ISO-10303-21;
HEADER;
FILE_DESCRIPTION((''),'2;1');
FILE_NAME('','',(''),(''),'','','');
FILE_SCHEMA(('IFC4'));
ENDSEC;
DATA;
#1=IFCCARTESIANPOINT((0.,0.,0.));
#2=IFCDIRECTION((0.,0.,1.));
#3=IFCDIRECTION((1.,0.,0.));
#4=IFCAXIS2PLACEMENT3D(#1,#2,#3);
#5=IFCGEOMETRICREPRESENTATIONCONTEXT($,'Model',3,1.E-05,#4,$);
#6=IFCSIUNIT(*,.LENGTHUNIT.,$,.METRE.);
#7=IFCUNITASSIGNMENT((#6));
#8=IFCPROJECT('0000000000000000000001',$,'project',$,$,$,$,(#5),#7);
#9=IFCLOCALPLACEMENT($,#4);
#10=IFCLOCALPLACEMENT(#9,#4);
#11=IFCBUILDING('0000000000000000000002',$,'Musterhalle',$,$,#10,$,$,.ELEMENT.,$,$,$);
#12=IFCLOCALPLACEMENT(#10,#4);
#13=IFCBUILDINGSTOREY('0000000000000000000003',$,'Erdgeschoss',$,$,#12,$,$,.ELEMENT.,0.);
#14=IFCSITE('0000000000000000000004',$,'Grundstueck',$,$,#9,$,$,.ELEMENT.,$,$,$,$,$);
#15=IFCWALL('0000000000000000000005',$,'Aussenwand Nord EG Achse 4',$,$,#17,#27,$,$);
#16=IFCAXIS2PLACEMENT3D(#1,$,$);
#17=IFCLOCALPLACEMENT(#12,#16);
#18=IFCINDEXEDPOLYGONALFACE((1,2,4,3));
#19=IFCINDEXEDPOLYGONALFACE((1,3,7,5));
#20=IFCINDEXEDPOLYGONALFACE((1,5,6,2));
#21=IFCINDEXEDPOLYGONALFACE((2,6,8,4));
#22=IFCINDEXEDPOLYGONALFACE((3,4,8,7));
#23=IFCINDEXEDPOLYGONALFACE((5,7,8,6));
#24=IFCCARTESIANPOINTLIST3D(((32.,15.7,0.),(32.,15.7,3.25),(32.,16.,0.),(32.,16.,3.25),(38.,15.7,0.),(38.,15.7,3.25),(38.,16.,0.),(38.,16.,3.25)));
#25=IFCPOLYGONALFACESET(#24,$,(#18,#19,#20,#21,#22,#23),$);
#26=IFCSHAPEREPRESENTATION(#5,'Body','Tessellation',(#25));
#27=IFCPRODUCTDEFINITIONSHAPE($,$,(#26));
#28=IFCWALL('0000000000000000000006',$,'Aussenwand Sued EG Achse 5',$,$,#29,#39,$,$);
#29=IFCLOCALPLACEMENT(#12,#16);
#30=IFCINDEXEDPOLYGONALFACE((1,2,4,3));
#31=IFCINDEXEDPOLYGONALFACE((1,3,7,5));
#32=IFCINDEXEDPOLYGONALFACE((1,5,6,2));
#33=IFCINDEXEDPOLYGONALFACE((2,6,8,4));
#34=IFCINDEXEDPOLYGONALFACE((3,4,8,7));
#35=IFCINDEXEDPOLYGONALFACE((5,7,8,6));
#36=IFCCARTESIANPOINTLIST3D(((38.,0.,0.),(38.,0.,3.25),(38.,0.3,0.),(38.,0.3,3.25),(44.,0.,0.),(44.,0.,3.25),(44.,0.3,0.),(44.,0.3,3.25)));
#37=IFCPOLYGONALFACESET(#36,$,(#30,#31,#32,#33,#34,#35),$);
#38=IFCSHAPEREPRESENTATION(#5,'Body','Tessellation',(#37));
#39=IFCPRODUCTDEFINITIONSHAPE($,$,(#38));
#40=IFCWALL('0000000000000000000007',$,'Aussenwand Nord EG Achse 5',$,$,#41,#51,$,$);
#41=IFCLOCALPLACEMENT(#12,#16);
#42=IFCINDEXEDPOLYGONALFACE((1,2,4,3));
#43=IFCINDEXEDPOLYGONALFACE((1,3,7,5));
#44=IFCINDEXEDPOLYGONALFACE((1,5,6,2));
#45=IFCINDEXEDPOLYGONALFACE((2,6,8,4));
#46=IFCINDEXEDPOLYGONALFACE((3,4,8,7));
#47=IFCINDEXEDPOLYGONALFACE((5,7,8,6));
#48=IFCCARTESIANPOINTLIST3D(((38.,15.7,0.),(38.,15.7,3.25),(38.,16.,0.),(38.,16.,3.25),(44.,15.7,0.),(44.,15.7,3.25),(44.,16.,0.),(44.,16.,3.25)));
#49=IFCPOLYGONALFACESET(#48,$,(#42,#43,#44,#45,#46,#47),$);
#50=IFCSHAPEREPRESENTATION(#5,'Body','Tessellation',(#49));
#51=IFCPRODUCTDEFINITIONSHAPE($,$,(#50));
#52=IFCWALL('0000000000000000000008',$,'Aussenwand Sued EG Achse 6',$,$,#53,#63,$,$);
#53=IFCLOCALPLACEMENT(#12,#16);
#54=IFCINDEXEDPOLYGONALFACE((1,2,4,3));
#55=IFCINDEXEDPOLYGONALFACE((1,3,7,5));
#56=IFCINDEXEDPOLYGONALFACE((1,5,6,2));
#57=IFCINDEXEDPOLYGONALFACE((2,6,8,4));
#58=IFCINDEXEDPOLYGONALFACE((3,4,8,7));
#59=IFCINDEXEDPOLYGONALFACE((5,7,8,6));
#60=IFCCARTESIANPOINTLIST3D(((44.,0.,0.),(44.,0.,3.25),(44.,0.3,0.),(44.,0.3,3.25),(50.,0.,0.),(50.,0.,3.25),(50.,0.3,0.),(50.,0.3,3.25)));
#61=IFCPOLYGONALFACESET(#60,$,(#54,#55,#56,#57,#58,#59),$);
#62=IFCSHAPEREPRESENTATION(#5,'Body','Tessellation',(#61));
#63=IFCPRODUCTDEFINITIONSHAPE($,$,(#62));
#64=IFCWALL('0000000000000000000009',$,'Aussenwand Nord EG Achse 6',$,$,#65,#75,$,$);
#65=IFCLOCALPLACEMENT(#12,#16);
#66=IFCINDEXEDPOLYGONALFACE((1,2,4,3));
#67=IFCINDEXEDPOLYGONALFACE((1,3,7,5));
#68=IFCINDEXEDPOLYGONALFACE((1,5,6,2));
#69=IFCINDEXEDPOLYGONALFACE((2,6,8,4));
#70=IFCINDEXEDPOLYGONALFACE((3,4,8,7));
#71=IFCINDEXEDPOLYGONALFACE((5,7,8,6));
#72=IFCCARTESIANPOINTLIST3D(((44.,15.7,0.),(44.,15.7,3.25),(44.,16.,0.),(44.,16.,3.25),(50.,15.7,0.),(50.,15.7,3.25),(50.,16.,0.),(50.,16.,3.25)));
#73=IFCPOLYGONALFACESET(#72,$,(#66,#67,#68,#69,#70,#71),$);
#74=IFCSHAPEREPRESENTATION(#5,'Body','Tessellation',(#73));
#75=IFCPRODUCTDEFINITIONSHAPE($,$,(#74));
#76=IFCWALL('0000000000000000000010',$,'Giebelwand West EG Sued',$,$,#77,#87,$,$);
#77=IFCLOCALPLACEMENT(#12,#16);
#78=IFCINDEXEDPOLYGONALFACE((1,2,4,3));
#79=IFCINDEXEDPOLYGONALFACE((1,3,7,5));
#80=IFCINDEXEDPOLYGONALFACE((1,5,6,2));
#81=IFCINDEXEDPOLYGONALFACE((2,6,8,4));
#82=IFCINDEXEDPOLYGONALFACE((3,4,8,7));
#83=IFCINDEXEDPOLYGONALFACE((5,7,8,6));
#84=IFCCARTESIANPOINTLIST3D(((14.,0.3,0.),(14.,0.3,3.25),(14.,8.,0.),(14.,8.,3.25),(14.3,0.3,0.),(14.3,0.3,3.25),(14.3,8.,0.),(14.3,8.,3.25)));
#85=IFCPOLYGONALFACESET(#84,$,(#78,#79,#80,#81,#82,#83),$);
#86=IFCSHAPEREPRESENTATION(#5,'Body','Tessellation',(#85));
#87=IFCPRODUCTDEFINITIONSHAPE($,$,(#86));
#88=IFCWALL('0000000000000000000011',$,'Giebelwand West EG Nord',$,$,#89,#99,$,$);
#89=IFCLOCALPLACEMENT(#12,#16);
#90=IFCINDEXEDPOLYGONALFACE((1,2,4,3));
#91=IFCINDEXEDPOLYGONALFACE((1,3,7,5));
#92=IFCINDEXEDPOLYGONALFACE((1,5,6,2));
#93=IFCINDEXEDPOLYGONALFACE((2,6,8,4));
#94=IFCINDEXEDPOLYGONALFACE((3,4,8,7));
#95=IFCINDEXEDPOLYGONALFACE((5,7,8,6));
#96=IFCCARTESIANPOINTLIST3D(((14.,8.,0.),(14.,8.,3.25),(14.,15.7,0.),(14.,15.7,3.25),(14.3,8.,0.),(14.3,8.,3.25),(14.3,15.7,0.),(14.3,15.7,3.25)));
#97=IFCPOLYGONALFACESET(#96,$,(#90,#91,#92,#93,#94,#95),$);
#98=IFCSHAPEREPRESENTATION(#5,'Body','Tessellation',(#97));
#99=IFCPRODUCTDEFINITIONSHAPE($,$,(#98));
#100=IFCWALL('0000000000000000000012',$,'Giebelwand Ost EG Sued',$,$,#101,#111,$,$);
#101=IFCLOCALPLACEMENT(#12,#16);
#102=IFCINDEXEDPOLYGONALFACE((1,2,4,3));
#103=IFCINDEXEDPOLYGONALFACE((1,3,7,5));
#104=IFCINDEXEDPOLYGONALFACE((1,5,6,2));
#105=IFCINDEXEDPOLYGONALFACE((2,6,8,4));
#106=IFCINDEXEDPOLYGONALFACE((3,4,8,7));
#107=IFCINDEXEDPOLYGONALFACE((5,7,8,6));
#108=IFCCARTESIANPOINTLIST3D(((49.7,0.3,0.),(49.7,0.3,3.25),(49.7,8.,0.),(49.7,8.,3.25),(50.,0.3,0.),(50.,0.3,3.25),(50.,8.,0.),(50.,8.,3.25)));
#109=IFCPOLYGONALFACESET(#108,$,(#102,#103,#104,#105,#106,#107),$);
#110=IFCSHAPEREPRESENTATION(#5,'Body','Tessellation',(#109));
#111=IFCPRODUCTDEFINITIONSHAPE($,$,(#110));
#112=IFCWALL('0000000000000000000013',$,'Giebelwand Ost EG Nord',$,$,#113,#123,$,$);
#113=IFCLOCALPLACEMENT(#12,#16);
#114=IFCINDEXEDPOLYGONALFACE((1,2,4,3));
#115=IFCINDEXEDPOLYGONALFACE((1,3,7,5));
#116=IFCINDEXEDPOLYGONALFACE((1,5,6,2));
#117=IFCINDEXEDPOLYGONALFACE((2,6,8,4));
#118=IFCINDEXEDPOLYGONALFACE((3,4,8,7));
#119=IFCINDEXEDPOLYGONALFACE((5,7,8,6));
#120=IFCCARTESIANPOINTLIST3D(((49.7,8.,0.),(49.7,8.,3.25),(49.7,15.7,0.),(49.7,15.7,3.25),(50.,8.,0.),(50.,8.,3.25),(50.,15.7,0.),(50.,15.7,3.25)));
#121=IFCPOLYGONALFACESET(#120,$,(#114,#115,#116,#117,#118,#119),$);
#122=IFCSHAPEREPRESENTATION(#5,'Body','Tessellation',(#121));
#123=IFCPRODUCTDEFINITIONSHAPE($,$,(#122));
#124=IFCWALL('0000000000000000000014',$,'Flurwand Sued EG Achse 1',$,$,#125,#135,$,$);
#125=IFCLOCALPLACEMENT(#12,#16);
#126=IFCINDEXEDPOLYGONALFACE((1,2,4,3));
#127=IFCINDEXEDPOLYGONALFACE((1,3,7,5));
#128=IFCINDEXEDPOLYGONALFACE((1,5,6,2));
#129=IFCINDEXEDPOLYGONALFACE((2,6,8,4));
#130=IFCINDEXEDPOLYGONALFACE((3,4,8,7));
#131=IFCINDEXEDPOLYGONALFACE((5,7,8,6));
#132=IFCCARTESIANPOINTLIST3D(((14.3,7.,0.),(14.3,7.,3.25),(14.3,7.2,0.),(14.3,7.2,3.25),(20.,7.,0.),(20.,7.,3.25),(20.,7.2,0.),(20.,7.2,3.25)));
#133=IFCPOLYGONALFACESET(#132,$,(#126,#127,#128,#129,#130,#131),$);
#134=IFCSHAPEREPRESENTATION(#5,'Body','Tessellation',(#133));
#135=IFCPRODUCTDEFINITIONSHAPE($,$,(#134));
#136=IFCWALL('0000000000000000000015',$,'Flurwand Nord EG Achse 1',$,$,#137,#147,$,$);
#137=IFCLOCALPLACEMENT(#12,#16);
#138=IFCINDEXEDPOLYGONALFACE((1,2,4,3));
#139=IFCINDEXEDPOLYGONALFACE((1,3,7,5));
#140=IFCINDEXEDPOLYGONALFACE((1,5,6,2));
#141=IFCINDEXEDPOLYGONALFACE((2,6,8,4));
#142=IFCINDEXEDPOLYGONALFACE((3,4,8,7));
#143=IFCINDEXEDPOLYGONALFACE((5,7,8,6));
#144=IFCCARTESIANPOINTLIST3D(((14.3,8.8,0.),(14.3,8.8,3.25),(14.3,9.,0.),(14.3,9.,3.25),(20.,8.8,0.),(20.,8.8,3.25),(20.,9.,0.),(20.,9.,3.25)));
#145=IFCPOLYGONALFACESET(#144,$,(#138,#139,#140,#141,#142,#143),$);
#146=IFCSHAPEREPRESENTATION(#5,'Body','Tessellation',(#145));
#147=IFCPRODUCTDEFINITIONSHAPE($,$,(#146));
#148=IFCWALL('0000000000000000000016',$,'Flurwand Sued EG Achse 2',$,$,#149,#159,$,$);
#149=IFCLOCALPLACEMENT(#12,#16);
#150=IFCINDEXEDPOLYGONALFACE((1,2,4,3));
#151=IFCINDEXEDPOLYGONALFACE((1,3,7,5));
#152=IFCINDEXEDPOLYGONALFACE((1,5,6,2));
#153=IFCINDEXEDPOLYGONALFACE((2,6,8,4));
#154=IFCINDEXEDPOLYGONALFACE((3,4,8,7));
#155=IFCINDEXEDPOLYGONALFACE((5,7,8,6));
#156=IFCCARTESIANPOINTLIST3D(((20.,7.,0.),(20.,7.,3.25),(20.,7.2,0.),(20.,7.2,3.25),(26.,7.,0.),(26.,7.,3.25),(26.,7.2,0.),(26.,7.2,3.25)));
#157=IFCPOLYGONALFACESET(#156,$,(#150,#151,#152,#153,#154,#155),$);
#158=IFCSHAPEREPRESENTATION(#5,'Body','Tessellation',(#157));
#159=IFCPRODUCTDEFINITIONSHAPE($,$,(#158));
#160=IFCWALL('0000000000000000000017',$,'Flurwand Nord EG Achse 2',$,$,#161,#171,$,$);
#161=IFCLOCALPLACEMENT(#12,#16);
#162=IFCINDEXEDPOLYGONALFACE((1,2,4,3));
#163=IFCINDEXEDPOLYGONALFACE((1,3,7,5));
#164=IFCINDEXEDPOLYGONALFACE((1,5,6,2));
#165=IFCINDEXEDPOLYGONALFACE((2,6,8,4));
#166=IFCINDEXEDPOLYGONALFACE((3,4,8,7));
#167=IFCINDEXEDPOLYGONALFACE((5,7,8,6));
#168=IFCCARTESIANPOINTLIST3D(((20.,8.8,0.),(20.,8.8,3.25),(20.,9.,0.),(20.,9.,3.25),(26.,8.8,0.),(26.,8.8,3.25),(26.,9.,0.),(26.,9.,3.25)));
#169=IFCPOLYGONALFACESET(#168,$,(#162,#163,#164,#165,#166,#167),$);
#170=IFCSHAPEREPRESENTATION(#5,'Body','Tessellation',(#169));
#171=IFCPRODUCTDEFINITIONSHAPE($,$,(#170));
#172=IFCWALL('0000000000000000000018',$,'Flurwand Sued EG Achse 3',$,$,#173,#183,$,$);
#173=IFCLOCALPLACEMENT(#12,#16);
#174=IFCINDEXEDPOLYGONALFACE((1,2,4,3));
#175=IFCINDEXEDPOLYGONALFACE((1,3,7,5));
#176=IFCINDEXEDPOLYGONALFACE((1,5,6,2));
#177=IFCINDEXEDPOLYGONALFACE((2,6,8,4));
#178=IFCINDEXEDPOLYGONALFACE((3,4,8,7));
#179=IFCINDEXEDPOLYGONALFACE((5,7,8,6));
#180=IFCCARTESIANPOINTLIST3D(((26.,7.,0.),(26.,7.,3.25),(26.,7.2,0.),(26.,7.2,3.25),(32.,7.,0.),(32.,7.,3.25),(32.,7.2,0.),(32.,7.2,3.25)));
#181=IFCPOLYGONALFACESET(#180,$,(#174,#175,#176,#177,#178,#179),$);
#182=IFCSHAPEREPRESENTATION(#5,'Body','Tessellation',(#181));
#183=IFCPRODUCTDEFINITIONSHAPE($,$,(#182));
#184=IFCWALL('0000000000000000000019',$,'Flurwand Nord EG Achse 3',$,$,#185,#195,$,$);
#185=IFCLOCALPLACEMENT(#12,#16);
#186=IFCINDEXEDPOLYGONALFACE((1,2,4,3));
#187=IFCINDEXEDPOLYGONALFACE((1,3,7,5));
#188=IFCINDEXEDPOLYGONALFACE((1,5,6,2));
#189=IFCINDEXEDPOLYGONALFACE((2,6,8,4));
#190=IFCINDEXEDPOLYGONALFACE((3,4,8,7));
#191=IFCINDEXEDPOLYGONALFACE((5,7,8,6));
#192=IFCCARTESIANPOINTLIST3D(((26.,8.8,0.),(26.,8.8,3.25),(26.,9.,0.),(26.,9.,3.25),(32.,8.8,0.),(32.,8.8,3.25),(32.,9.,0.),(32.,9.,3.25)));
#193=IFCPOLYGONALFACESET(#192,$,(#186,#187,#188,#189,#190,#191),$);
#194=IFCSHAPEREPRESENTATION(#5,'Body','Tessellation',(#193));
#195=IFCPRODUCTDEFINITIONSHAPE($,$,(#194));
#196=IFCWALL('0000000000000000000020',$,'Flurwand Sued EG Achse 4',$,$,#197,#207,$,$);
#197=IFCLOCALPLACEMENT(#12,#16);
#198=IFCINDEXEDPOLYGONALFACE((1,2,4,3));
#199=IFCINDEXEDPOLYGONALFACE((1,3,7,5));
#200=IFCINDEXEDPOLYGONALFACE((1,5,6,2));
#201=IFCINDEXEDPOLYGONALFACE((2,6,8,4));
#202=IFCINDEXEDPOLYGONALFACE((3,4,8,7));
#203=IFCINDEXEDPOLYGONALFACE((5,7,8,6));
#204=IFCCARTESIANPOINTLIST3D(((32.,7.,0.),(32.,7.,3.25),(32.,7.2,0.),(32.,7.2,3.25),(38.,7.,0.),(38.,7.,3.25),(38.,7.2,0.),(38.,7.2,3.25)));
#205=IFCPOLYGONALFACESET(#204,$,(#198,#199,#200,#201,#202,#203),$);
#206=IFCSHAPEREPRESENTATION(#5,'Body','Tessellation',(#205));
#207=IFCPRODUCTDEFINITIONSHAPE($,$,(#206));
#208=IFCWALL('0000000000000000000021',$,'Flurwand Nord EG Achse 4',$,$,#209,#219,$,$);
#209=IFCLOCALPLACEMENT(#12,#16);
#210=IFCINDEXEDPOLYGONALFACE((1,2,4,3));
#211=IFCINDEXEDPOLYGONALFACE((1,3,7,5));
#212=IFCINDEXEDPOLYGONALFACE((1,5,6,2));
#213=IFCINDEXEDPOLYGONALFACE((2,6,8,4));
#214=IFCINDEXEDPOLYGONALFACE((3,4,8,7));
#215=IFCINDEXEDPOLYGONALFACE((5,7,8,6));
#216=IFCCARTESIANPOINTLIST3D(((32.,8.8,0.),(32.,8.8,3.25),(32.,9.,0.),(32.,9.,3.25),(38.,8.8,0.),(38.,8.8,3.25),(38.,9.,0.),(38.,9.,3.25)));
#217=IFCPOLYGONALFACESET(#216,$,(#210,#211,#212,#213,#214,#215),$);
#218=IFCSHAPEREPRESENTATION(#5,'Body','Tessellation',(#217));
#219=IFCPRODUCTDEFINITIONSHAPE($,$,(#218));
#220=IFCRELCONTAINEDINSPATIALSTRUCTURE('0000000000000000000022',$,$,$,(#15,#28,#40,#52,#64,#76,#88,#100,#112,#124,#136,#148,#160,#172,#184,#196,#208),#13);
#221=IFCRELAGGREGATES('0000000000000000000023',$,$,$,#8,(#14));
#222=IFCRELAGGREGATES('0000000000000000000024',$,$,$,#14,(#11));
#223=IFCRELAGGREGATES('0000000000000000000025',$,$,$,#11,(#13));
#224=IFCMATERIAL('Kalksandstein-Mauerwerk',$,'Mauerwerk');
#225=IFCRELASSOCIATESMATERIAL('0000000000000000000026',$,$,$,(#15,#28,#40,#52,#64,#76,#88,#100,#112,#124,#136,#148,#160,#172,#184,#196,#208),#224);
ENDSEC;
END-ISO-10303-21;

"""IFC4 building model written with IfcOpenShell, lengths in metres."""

from ifc_helpers import new_model, si_unit, frame, origin_with_axes, origin_2d, place, context, project, spatial, rectangle, extrude, material, element, save


model = new_model("IFC4")

# Units and contexts
model_context = context("Model", 3, precision=1e-05, world=origin_with_axes())
ifc_project = project(units=[si_unit("LENGTHUNIT", "METRE")], contexts=[model_context])

# Site, building, storey
site_placement = place(None, origin_with_axes())
site = spatial("IfcSite", under=ifc_project, at=site_placement, Name="Grundstueck", CompositionType="ELEMENT")
building_placement = place(site_placement, origin_with_axes())
building = spatial("IfcBuilding", under=site, at=building_placement, Name="Musterhalle", CompositionType="ELEMENT")
storey_placement = place(building_placement, origin_with_axes())
storey = spatial("IfcBuildingStorey", under=building, at=storey_placement, Name="Erdgeschoss", CompositionType="ELEMENT", Elevation=0.0)

# Walls
ifc_material_1 = material(Name="Kalksandstein-Mauerwerk", Category="Mauerwerk")
placement = place(storey_placement, origin_with_axes())
element("IfcWall", 1, at=placement, inside=storey, material=ifc_material_1, Name="Aussenwand Nord EG Achse 4", context=model_context, shape_type="SweptSolid", body=[
    extrude(rectangle(XDim=6.0, YDim=0.3, at=origin_2d()), frame((35.0, 15.85, 0.0), z_axis=(0.0, 0.0, 1.0), x_axis=(1.0, 0.0, 0.0)), (0.0, 0.0, 1.0), 3.25),
])
element("IfcWall", 2, at=placement, inside=storey, material=ifc_material_1, Name="Aussenwand Sued EG Achse 5", context=model_context, shape_type="SweptSolid", body=[
    extrude(rectangle(XDim=6.0, YDim=0.3, at=origin_2d()), frame((41.0, 0.15, 0.0), z_axis=(0.0, 0.0, 1.0), x_axis=(1.0, 0.0, 0.0)), (0.0, 0.0, 1.0), 3.25),
])
element("IfcWall", 3, at=placement, inside=storey, material=ifc_material_1, Name="Aussenwand Nord EG Achse 5", context=model_context, shape_type="SweptSolid", body=[
    extrude(rectangle(XDim=6.0, YDim=0.3, at=origin_2d()), frame((41.0, 15.85, 0.0), z_axis=(0.0, 0.0, 1.0), x_axis=(1.0, 0.0, 0.0)), (0.0, 0.0, 1.0), 3.25),
])
element("IfcWall", 4, at=placement, inside=storey, material=ifc_material_1, Name="Aussenwand Sued EG Achse 6", context=model_context, shape_type="SweptSolid", body=[
    extrude(rectangle(XDim=6.0, YDim=0.3, at=origin_2d()), frame((47.0, 0.15, 0.0), z_axis=(0.0, 0.0, 1.0), x_axis=(1.0, 0.0, 0.0)), (0.0, 0.0, 1.0), 3.25),
])
element("IfcWall", 5, at=placement, inside=storey, material=ifc_material_1, Name="Aussenwand Nord EG Achse 6", context=model_context, shape_type="SweptSolid", body=[
    extrude(rectangle(XDim=6.0, YDim=0.3, at=origin_2d()), frame((47.0, 15.85, 0.0), z_axis=(0.0, 0.0, 1.0), x_axis=(1.0, 0.0, 0.0)), (0.0, 0.0, 1.0), 3.25),
])
element("IfcWall", 6, at=placement, inside=storey, material=ifc_material_1, Name="Giebelwand West EG Sued", context=model_context, shape_type="SweptSolid", body=[
    extrude(rectangle(XDim=0.3, YDim=7.7, at=origin_2d()), frame((14.15, 4.15, 0.0), z_axis=(0.0, 0.0, 1.0), x_axis=(1.0, 0.0, 0.0)), (0.0, 0.0, 1.0), 3.25),
])
element("IfcWall", 7, at=placement, inside=storey, material=ifc_material_1, Name="Giebelwand West EG Nord", context=model_context, shape_type="SweptSolid", body=[
    extrude(rectangle(XDim=0.3, YDim=7.7, at=origin_2d()), frame((14.15, 11.85, 0.0), z_axis=(0.0, 0.0, 1.0), x_axis=(1.0, 0.0, 0.0)), (0.0, 0.0, 1.0), 3.25),
])
element("IfcWall", 8, at=placement, inside=storey, material=ifc_material_1, Name="Giebelwand Ost EG Sued", context=model_context, shape_type="SweptSolid", body=[
    extrude(rectangle(XDim=0.3, YDim=7.7, at=origin_2d()), frame((49.85, 4.15, 0.0), z_axis=(0.0, 0.0, 1.0), x_axis=(1.0, 0.0, 0.0)), (0.0, 0.0, 1.0), 3.25),
])
element("IfcWall", 9, at=placement, inside=storey, material=ifc_material_1, Name="Giebelwand Ost EG Nord", context=model_context, shape_type="SweptSolid", body=[
    extrude(rectangle(XDim=0.3, YDim=7.7, at=origin_2d()), frame((49.85, 11.85, 0.0), z_axis=(0.0, 0.0, 1.0), x_axis=(1.0, 0.0, 0.0)), (0.0, 0.0, 1.0), 3.25),
])
element("IfcWall", 10, at=placement, inside=storey, material=ifc_material_1, Name="Flurwand Sued EG Achse 1", context=model_context, shape_type="SweptSolid", body=[
    extrude(rectangle(XDim=5.7, YDim=0.2, at=origin_2d()), frame((17.15, 7.1, 0.0), z_axis=(0.0, 0.0, 1.0), x_axis=(1.0, 0.0, 0.0)), (0.0, 0.0, 1.0), 3.25),
])
element("IfcWall", 11, at=placement, inside=storey, material=ifc_material_1, Name="Flurwand Nord EG Achse 1", context=model_context, shape_type="SweptSolid", body=[
    extrude(rectangle(XDim=5.7, YDim=0.2, at=origin_2d()), frame((17.15, 8.9, 0.0), z_axis=(0.0, 0.0, 1.0), x_axis=(1.0, 0.0, 0.0)), (0.0, 0.0, 1.0), 3.25),
])
element("IfcWall", 12, at=placement, inside=storey, material=ifc_material_1, Name="Flurwand Sued EG Achse 2", context=model_context, shape_type="SweptSolid", body=[
    extrude(rectangle(XDim=6.0, YDim=0.2, at=origin_2d()), frame((23.0, 7.1, 0.0), z_axis=(0.0, 0.0, 1.0), x_axis=(1.0, 0.0, 0.0)), (0.0, 0.0, 1.0), 3.25),
])
element("IfcWall", 13, at=placement, inside=storey, material=ifc_material_1, Name="Flurwand Nord EG Achse 2", context=model_context, shape_type="SweptSolid", body=[
    extrude(rectangle(XDim=6.0, YDim=0.2, at=origin_2d()), frame((23.0, 8.9, 0.0), z_axis=(0.0, 0.0, 1.0), x_axis=(1.0, 0.0, 0.0)), (0.0, 0.0, 1.0), 3.25),
])
element("IfcWall", 14, at=placement, inside=storey, material=ifc_material_1, Name="Flurwand Sued EG Achse 3", context=model_context, shape_type="SweptSolid", body=[
    extrude(rectangle(XDim=6.0, YDim=0.2, at=origin_2d()), frame((29.0, 7.1, 0.0), z_axis=(0.0, 0.0, 1.0), x_axis=(1.0, 0.0, 0.0)), (0.0, 0.0, 1.0), 3.25),
])
element("IfcWall", 15, at=placement, inside=storey, material=ifc_material_1, Name="Flurwand Nord EG Achse 3", context=model_context, shape_type="SweptSolid", body=[
    extrude(rectangle(XDim=6.0, YDim=0.2, at=origin_2d()), frame((29.0, 8.9, 0.0), z_axis=(0.0, 0.0, 1.0), x_axis=(1.0, 0.0, 0.0)), (0.0, 0.0, 1.0), 3.25),
])
element("IfcWall", 16, at=placement, inside=storey, material=ifc_material_1, Name="Flurwand Sued EG Achse 4", context=model_context, shape_type="SweptSolid", body=[
    extrude(rectangle(XDim=6.0, YDim=0.2, at=origin_2d()), frame((35.0, 7.1, 0.0), z_axis=(0.0, 0.0, 1.0), x_axis=(1.0, 0.0, 0.0)), (0.0, 0.0, 1.0), 3.25),
])
element("IfcWall", 17, at=placement, inside=storey, material=ifc_material_1, Name="Flurwand Nord EG Achse 4", context=model_context, shape_type="SweptSolid", body=[
    extrude(rectangle(XDim=6.0, YDim=0.2, at=origin_2d()), frame((35.0, 8.9, 0.0), z_axis=(0.0, 0.0, 1.0), x_axis=(1.0, 0.0, 0.0)), (0.0, 0.0, 1.0), 3.25),
])

save(model, "model.ifc")
